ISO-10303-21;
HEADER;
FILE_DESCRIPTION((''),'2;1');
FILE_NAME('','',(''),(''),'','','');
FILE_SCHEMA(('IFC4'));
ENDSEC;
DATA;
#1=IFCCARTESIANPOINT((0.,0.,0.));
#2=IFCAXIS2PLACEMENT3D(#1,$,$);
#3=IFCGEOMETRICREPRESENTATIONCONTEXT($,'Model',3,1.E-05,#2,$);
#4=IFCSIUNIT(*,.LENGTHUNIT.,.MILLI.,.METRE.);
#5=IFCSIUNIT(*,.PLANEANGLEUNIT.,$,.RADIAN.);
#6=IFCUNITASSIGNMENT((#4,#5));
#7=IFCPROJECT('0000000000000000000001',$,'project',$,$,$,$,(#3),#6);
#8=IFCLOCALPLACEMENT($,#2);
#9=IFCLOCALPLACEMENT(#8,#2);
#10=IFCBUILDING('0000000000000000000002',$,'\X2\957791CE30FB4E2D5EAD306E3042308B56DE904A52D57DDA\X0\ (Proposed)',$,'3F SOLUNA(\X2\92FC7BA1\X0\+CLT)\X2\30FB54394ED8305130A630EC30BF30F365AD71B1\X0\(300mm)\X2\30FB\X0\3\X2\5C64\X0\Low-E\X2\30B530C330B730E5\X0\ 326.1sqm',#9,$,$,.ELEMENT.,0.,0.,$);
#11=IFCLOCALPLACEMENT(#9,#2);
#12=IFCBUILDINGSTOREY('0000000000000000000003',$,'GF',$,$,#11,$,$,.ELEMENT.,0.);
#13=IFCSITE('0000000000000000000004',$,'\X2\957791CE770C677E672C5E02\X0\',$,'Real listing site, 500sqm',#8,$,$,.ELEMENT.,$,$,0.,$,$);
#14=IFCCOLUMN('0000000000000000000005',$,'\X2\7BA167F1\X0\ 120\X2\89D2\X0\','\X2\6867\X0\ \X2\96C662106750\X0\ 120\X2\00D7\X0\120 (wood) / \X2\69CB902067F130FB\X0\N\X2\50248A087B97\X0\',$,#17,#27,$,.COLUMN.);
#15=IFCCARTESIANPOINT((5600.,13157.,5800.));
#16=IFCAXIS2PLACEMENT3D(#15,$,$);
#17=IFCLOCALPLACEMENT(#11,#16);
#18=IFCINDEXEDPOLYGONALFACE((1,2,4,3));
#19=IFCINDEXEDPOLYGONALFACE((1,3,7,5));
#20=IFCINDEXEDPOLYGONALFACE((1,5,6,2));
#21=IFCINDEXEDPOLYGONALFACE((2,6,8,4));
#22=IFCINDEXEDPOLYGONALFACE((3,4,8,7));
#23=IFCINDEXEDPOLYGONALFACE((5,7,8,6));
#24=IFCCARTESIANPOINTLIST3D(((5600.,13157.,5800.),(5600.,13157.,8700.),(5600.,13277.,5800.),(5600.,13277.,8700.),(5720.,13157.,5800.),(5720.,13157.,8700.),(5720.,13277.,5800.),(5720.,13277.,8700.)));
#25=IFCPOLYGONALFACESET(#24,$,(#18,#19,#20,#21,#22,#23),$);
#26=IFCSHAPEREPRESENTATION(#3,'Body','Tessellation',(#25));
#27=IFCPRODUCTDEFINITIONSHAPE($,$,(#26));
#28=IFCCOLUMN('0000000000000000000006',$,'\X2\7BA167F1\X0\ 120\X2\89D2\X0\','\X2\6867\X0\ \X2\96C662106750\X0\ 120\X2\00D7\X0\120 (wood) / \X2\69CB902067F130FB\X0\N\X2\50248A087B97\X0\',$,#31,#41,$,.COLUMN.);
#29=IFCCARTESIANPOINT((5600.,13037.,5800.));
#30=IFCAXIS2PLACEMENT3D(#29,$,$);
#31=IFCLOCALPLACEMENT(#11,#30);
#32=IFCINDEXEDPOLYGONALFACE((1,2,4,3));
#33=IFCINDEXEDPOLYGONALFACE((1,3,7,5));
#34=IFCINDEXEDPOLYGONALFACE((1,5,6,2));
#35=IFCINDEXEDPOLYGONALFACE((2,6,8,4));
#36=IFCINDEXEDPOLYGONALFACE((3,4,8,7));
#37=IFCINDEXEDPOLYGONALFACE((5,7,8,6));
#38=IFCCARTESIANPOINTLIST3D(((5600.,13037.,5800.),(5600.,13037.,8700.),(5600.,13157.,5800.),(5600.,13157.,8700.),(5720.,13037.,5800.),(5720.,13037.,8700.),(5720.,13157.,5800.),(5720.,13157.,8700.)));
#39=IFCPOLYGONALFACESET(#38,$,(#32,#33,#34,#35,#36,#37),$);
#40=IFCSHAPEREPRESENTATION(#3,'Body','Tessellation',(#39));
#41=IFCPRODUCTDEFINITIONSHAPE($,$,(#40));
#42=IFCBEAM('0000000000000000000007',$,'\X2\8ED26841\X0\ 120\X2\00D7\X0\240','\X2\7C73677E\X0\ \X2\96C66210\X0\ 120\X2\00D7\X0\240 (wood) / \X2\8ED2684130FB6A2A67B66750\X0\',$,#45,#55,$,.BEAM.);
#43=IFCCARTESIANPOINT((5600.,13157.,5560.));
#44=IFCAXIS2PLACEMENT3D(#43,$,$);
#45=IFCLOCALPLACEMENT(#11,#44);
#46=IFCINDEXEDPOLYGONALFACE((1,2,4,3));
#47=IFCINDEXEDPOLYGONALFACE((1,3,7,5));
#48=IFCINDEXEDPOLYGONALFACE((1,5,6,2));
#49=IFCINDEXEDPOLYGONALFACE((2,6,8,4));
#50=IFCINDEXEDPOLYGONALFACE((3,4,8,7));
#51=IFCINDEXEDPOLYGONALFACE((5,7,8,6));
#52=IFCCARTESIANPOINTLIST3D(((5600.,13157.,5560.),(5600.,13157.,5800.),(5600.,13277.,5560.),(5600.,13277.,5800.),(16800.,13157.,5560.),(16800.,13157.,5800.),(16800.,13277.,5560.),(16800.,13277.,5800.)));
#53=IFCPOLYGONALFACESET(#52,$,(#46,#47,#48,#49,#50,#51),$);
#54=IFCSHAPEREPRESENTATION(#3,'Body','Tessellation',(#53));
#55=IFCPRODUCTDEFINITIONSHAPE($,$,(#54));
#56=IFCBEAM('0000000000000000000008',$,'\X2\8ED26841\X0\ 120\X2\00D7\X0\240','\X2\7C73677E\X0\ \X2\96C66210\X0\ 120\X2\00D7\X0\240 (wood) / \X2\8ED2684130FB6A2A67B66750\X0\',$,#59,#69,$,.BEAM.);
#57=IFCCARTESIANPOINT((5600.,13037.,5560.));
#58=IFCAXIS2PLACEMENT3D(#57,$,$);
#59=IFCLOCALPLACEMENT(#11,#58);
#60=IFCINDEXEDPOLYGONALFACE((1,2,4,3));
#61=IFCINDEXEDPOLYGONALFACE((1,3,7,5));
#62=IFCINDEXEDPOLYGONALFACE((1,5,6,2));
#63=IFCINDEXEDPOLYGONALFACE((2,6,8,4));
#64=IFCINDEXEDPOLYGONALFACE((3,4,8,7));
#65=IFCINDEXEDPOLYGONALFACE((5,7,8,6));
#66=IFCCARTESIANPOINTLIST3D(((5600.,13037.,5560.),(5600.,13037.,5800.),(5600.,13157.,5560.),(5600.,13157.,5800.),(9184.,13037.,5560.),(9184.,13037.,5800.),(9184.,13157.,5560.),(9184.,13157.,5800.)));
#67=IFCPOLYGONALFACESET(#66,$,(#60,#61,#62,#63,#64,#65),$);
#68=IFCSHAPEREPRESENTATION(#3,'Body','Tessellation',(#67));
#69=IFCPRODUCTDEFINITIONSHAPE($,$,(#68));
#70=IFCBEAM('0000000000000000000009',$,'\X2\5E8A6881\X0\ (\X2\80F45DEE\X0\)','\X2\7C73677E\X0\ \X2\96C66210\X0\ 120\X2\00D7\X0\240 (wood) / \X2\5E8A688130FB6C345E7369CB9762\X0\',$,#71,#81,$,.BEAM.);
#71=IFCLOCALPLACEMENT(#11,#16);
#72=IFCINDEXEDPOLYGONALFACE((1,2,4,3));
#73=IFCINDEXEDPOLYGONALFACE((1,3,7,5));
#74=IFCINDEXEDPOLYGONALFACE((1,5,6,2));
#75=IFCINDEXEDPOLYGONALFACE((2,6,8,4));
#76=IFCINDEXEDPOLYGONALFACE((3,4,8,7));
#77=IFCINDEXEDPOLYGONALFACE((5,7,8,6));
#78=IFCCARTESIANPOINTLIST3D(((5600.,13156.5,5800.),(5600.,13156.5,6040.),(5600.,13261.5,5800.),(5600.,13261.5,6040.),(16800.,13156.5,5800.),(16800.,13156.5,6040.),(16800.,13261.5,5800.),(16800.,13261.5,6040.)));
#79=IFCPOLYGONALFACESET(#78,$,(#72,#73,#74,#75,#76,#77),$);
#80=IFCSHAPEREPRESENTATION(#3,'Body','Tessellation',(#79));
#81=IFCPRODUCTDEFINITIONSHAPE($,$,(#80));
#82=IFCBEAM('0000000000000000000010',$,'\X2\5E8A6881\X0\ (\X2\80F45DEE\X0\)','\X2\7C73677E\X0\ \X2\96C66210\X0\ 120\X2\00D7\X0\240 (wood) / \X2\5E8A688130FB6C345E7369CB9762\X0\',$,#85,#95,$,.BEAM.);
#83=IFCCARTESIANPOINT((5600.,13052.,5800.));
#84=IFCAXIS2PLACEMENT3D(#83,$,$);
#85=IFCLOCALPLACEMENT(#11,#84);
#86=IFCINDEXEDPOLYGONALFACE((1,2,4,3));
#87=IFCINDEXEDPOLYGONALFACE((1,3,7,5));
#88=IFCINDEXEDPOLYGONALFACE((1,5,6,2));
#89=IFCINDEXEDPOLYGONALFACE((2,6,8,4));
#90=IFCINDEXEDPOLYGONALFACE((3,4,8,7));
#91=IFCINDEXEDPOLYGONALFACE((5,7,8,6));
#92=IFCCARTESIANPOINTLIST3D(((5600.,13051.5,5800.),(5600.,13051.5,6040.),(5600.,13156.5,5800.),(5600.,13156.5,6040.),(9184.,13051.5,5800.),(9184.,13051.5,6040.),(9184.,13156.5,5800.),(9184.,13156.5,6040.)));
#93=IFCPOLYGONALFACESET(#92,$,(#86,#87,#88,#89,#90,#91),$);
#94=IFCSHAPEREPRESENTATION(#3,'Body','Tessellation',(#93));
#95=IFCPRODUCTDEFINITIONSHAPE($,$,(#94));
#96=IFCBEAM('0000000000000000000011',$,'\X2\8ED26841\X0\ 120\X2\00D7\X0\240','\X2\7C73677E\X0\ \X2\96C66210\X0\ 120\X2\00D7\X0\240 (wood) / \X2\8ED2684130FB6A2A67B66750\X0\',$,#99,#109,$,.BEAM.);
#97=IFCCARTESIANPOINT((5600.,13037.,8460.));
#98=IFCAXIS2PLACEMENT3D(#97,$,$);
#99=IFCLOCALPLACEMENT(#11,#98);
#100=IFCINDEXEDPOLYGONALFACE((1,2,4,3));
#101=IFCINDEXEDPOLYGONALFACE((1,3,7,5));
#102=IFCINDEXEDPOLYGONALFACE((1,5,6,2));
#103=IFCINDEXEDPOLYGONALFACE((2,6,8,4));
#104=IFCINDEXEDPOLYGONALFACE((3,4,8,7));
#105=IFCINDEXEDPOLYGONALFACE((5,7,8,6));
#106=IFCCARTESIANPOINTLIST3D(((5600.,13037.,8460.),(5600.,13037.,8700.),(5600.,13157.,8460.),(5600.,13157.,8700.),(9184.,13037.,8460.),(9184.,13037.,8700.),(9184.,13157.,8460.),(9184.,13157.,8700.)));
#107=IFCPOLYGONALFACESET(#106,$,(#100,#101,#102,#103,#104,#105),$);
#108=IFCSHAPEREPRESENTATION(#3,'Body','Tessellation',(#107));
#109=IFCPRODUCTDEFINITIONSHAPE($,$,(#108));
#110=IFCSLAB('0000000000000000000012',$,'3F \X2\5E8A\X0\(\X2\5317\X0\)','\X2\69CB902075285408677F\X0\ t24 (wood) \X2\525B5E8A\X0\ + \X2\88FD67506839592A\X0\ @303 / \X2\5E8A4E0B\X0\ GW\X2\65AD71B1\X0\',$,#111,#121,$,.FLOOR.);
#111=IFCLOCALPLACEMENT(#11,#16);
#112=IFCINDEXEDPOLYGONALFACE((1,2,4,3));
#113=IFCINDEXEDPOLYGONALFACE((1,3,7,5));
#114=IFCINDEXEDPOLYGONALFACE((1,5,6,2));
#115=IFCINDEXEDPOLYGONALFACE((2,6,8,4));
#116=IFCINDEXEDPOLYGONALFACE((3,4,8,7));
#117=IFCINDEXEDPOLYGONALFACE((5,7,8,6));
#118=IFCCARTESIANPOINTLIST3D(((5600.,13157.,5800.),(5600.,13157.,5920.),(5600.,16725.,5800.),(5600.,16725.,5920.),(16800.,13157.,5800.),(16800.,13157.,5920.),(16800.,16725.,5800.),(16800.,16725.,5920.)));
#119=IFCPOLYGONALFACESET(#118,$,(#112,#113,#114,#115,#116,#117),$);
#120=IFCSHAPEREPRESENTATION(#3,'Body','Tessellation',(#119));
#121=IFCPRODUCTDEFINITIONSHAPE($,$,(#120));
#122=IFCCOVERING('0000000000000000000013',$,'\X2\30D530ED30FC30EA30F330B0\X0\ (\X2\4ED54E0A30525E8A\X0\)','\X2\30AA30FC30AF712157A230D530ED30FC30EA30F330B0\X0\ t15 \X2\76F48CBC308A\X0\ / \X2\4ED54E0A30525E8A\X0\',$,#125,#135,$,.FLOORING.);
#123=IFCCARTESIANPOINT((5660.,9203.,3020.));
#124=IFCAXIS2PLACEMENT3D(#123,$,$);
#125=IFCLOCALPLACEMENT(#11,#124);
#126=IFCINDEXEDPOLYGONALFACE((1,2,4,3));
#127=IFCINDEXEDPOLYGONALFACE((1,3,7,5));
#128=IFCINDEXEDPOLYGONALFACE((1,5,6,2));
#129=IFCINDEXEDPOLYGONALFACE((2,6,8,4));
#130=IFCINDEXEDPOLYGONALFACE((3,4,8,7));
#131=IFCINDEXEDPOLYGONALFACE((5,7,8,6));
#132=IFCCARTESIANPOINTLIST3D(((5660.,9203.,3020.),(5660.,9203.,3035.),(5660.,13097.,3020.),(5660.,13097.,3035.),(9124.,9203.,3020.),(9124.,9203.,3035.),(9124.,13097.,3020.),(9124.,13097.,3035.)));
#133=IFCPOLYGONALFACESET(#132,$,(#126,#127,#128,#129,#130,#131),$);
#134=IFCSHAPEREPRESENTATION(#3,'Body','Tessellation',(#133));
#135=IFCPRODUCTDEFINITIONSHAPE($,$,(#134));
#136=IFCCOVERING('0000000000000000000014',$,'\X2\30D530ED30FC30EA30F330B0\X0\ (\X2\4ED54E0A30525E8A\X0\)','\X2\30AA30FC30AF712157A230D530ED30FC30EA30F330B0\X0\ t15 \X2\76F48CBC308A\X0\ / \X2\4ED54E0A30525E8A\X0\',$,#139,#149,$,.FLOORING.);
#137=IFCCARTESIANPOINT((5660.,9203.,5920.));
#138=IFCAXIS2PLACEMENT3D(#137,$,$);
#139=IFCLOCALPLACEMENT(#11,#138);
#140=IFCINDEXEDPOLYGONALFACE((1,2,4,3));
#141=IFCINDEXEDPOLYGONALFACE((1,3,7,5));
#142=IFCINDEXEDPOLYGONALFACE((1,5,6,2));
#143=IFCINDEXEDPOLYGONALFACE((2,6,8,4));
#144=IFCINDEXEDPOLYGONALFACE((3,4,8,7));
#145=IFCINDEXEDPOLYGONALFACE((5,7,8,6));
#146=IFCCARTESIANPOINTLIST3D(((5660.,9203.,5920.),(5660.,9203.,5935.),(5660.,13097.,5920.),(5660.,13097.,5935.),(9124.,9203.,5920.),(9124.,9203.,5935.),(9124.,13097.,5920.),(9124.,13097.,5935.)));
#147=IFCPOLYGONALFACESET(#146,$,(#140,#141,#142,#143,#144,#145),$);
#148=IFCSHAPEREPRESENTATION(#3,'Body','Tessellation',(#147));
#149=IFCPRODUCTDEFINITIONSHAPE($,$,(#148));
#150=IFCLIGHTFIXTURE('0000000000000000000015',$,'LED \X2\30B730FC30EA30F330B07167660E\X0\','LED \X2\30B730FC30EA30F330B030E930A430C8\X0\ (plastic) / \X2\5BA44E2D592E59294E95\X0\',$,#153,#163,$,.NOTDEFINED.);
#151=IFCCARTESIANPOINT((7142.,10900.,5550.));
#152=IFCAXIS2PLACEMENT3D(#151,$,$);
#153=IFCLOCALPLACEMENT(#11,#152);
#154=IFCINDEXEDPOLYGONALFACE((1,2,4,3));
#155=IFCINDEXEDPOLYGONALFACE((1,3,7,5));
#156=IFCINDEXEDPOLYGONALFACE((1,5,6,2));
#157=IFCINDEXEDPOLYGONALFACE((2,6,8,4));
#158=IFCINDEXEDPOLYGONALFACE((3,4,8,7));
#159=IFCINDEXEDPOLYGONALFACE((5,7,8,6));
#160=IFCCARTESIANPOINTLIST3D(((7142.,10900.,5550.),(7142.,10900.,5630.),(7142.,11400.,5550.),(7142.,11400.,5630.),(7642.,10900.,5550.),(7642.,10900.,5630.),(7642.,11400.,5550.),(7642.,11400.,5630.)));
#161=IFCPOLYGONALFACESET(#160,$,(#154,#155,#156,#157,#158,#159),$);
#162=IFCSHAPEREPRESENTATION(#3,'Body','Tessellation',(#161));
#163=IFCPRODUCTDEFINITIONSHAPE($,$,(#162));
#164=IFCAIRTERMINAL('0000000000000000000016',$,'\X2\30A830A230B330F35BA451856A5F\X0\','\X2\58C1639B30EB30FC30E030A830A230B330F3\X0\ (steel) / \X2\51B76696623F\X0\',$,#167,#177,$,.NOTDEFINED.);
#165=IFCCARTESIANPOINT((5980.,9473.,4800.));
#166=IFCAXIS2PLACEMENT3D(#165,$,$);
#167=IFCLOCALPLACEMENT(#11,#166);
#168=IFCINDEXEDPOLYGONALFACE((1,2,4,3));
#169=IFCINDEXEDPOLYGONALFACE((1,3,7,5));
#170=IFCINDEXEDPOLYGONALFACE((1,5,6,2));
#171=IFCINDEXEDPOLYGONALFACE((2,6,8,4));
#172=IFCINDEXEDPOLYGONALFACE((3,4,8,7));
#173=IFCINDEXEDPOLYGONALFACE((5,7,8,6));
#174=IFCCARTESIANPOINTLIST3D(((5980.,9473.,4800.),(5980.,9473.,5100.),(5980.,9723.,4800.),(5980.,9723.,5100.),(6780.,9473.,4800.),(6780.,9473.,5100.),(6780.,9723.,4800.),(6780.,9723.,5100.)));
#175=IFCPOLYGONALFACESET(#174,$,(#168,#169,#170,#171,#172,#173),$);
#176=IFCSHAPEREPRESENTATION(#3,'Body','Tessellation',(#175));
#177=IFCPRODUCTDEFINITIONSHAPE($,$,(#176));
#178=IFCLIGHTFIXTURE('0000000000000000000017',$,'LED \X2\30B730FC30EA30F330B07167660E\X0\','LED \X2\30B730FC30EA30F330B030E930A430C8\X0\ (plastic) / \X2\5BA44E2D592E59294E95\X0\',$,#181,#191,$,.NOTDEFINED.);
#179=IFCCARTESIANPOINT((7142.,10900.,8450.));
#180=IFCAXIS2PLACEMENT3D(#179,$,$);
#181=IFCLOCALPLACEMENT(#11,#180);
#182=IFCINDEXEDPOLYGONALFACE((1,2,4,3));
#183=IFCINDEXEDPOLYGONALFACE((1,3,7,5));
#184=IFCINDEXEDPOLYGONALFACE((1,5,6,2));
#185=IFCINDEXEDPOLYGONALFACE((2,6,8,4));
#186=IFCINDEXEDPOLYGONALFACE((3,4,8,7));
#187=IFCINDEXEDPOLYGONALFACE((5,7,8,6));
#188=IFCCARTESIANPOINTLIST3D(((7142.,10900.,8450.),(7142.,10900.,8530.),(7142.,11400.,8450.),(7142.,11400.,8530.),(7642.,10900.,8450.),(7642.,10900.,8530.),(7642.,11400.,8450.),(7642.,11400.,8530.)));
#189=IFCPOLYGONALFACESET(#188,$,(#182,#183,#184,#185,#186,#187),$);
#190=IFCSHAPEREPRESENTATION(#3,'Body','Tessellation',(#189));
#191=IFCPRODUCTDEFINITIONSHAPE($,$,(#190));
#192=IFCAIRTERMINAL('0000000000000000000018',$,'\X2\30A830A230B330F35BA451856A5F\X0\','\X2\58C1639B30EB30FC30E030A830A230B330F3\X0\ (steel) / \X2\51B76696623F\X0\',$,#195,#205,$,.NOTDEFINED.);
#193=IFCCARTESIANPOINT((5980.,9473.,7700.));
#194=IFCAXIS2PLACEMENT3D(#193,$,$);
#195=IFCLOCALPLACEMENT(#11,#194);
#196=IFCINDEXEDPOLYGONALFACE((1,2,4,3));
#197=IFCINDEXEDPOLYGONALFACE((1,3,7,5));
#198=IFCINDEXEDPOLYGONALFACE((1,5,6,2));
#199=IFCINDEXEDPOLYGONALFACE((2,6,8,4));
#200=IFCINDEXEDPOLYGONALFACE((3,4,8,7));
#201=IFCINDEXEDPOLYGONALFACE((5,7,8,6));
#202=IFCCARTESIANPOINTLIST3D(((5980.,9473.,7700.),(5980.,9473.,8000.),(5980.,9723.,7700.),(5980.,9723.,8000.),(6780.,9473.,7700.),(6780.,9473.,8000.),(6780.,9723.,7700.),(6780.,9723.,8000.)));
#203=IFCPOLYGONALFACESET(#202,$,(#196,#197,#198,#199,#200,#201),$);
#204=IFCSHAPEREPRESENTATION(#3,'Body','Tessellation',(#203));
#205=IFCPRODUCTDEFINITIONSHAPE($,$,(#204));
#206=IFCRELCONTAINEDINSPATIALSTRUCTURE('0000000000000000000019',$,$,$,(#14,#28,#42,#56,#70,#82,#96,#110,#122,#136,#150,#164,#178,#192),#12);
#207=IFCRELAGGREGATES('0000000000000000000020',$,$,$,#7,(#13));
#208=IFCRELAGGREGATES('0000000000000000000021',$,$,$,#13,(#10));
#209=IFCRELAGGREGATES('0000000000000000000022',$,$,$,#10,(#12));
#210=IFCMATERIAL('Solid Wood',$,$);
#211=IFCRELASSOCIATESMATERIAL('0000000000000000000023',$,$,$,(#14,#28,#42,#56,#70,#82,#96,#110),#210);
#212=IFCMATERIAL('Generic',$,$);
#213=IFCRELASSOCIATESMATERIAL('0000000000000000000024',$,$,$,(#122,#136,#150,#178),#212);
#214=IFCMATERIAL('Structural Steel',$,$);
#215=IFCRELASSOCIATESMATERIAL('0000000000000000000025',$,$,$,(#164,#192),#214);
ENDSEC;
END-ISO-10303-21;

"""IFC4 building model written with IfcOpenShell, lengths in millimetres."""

from ifc_helpers import new_model, si_unit, frame, frame_2d, origin, place, context, project, spatial, rectangle, extrude, material, element, save


model = new_model("IFC4")

# Units and contexts
model_context = context("Model", 3, precision=1e-05, world=origin())
ifc_project = project(units=[si_unit("LENGTHUNIT", "METRE", prefix="MILLI"), si_unit("PLANEANGLEUNIT", "RADIAN")], contexts=[model_context])

# Site, building, storey
site_placement = place(None, origin())
site = spatial("IfcSite", under=ifc_project, at=site_placement, Name="長野県松本市", ObjectType="Real listing site, 500sqm", CompositionType="ELEMENT", RefElevation=0.0)
building_placement = place(site_placement, origin())
building = spatial("IfcBuilding", under=site, at=building_placement, Name="長野・中庭のある回遊動線 (Proposed)", ObjectType="3F SOLUNA(鋼管+CLT)・吹付けウレタン断熱(300mm)・3層Low-Eサッシュ 326.1sqm", CompositionType="ELEMENT", ElevationOfRefHeight=0.0, ElevationOfTerrain=0.0)
storey_placement = place(building_placement, origin())
storey = spatial("IfcBuildingStorey", under=building, at=storey_placement, Name="GF", CompositionType="ELEMENT", Elevation=0.0)

# Columns
ifc_material_1 = material(Name="Solid Wood")
column_1_placement = place(storey_placement, frame((5600.0, 13157.0, 5800.0)))
element("IfcColumn", 1, at=column_1_placement, inside=storey, material=ifc_material_1, Name="管柱 120角", Description="桧 集成材 120×120 (wood) / 構造柱・N値計算", PredefinedType="COLUMN", context=model_context, shape_type="SweptSolid", body=[
    extrude(rectangle(XDim=120.0, YDim=120.0, at=frame_2d((60.0, 60.0))), frame((5600.0, 13157.0, 5800.0)), (0.0, 0.0, 1.0), 2900.0),
])
column_2_placement = place(storey_placement, frame((5600.0, 13037.0, 5800.0)))
element("IfcColumn", 2, at=column_2_placement, inside=storey, material=ifc_material_1, Name="管柱 120角", Description="桧 集成材 120×120 (wood) / 構造柱・N値計算", PredefinedType="COLUMN", context=model_context, shape_type="SweptSolid", body=[
    extrude(rectangle(XDim=120.0, YDim=120.0, at=frame_2d((60.0, 60.0))), frame((5600.0, 13037.0, 5800.0)), (0.0, 0.0, 1.0), 2900.0),
])

# Beams
beam_1_placement = place(storey_placement, frame((5600.0, 13157.0, 5560.0)))
element("IfcBeam", 3, at=beam_1_placement, inside=storey, material=ifc_material_1, Name="軒桁 120×240", Description="米松 集成 120×240 (wood) / 軒桁・横架材", PredefinedType="BEAM", context=model_context, shape_type="SweptSolid", body=[
    extrude(rectangle(XDim=11200.0, YDim=120.0, at=frame_2d((5600.0, 60.0))), frame((5600.0, 13157.0, 5560.0)), (0.0, 0.0, 1.0), 240.0),
])
beam_2_placement = place(storey_placement, frame((5600.0, 13037.0, 5560.0)))
element("IfcBeam", 4, at=beam_2_placement, inside=storey, material=ifc_material_1, Name="軒桁 120×240", Description="米松 集成 120×240 (wood) / 軒桁・横架材", PredefinedType="BEAM", context=model_context, shape_type="SweptSolid", body=[
    extrude(rectangle(XDim=3584.0, YDim=120.0, at=frame_2d((1792.0, 60.0))), frame((5600.0, 13037.0, 5560.0)), (0.0, 0.0, 1.0), 240.0),
])
beam_3_placement = place(storey_placement, frame((5600.0, 13157.0, 5800.0)))
element("IfcBeam", 5, at=beam_3_placement, inside=storey, material=ifc_material_1, Name="床梁 (胴差)", Description="米松 集成 120×240 (wood) / 床梁・水平構面", PredefinedType="BEAM", context=model_context, shape_type="SweptSolid", body=[
    extrude(rectangle(XDim=11200.0, YDim=105.0, at=frame_2d((5600.0, 52.0))), frame((5600.0, 13157.0, 5800.0)), (0.0, 0.0, 1.0), 240.0),
])
beam_4_placement = place(storey_placement, frame((5600.0, 13052.0, 5800.0)))
element("IfcBeam", 6, at=beam_4_placement, inside=storey, material=ifc_material_1, Name="床梁 (胴差)", Description="米松 集成 120×240 (wood) / 床梁・水平構面", PredefinedType="BEAM", context=model_context, shape_type="SweptSolid", body=[
    extrude(rectangle(XDim=3584.0, YDim=105.0, at=frame_2d((1792.0, 52.0))), frame((5600.0, 13052.0, 5800.0)), (0.0, 0.0, 1.0), 240.0),
])
beam_5_placement = place(storey_placement, frame((5600.0, 13037.0, 8460.0)))
element("IfcBeam", 7, at=beam_5_placement, inside=storey, material=ifc_material_1, Name="軒桁 120×240", Description="米松 集成 120×240 (wood) / 軒桁・横架材", PredefinedType="BEAM", context=model_context, shape_type="SweptSolid", body=[
    extrude(rectangle(XDim=3584.0, YDim=120.0, at=frame_2d((1792.0, 60.0))), frame((5600.0, 13037.0, 8460.0)), (0.0, 0.0, 1.0), 240.0),
])

# Slab
slab_placement = place(storey_placement, frame((5600.0, 13157.0, 5800.0)))
element("IfcSlab", 8, at=slab_placement, inside=storey, material=ifc_material_1, Name="3F 床(北)", Description="構造用合板 t24 (wood) 剛床 + 製材根太 @303 / 床下 GW断熱", PredefinedType="FLOOR", context=model_context, shape_type="SweptSolid", body=[
    extrude(rectangle(XDim=11200.0, YDim=3568.0, at=frame_2d((5600.0, 1784.0))), frame((5600.0, 13157.0, 5800.0)), (0.0, 0.0, 1.0), 120.0),
])

# Coverings
ifc_material_2 = material(Name="Generic")
covering_1_placement = place(storey_placement, frame((5660.0, 9203.0, 3020.0)))
element("IfcCovering", 9, at=covering_1_placement, inside=storey, material=ifc_material_2, Name="フローリング (仕上げ床)", Description="オーク無垢フローリング t15 直貼り / 仕上げ床", PredefinedType="FLOORING", context=model_context, shape_type="SweptSolid", body=[
    extrude(rectangle(XDim=3464.0, YDim=3894.0, at=frame_2d((1732.0, 1947.0))), frame((5660.0, 9203.0, 3020.0)), (0.0, 0.0, 1.0), 15.0),
])
covering_2_placement = place(storey_placement, frame((5660.0, 9203.0, 5920.0)))
element("IfcCovering", 10, at=covering_2_placement, inside=storey, material=ifc_material_2, Name="フローリング (仕上げ床)", Description="オーク無垢フローリング t15 直貼り / 仕上げ床", PredefinedType="FLOORING", context=model_context, shape_type="SweptSolid", body=[
    extrude(rectangle(XDim=3464.0, YDim=3894.0, at=frame_2d((1732.0, 1947.0))), frame((5660.0, 9203.0, 5920.0)), (0.0, 0.0, 1.0), 15.0),
])

# Light fixture
light_fixture_1_placement = place(storey_placement, frame((7142.0, 10900.0, 5550.0)))
element("IfcLightFixture", 11, at=light_fixture_1_placement, inside=storey, material=ifc_material_2, Name="LED シーリング照明", Description="LED シーリングライト (plastic) / 室中央天井", PredefinedType="NOTDEFINED", context=model_context, shape_type="SweptSolid", body=[
    extrude(rectangle(XDim=500.0, YDim=500.0, at=frame_2d((250.0, 250.0))), frame((7142.0, 10900.0, 5550.0)), (0.0, 0.0, 1.0), 80.0),
])

# Air terminal
ifc_material_3 = material(Name="Structural Steel")
air_terminal_1_placement = place(storey_placement, frame((5980.0, 9473.0, 4800.0)))
element("IfcAirTerminal", 12, at=air_terminal_1_placement, inside=storey, material=ifc_material_3, Name="エアコン室内機", Description="壁掛ルームエアコン (steel) / 冷暖房", PredefinedType="NOTDEFINED", context=model_context, shape_type="SweptSolid", body=[
    extrude(rectangle(XDim=800.0, YDim=250.0, at=frame_2d((400.0, 125.0))), frame((5980.0, 9473.0, 4800.0)), (0.0, 0.0, 1.0), 300.0),
])

# Light fixture
light_fixture_2_placement = place(storey_placement, frame((7142.0, 10900.0, 8450.0)))
element("IfcLightFixture", 13, at=light_fixture_2_placement, inside=storey, material=ifc_material_2, Name="LED シーリング照明", Description="LED シーリングライト (plastic) / 室中央天井", PredefinedType="NOTDEFINED", context=model_context, shape_type="SweptSolid", body=[
    extrude(rectangle(XDim=500.0, YDim=500.0, at=frame_2d((250.0, 250.0))), frame((7142.0, 10900.0, 8450.0)), (0.0, 0.0, 1.0), 80.0),
])

# Air terminal
air_terminal_2_placement = place(storey_placement, frame((5980.0, 9473.0, 7700.0)))
element("IfcAirTerminal", 14, at=air_terminal_2_placement, inside=storey, material=ifc_material_3, Name="エアコン室内機", Description="壁掛ルームエアコン (steel) / 冷暖房", PredefinedType="NOTDEFINED", context=model_context, shape_type="SweptSolid", body=[
    extrude(rectangle(XDim=800.0, YDim=250.0, at=frame_2d((400.0, 125.0))), frame((5980.0, 9473.0, 7700.0)), (0.0, 0.0, 1.0), 300.0),
])

save(model, "model.ifc")
